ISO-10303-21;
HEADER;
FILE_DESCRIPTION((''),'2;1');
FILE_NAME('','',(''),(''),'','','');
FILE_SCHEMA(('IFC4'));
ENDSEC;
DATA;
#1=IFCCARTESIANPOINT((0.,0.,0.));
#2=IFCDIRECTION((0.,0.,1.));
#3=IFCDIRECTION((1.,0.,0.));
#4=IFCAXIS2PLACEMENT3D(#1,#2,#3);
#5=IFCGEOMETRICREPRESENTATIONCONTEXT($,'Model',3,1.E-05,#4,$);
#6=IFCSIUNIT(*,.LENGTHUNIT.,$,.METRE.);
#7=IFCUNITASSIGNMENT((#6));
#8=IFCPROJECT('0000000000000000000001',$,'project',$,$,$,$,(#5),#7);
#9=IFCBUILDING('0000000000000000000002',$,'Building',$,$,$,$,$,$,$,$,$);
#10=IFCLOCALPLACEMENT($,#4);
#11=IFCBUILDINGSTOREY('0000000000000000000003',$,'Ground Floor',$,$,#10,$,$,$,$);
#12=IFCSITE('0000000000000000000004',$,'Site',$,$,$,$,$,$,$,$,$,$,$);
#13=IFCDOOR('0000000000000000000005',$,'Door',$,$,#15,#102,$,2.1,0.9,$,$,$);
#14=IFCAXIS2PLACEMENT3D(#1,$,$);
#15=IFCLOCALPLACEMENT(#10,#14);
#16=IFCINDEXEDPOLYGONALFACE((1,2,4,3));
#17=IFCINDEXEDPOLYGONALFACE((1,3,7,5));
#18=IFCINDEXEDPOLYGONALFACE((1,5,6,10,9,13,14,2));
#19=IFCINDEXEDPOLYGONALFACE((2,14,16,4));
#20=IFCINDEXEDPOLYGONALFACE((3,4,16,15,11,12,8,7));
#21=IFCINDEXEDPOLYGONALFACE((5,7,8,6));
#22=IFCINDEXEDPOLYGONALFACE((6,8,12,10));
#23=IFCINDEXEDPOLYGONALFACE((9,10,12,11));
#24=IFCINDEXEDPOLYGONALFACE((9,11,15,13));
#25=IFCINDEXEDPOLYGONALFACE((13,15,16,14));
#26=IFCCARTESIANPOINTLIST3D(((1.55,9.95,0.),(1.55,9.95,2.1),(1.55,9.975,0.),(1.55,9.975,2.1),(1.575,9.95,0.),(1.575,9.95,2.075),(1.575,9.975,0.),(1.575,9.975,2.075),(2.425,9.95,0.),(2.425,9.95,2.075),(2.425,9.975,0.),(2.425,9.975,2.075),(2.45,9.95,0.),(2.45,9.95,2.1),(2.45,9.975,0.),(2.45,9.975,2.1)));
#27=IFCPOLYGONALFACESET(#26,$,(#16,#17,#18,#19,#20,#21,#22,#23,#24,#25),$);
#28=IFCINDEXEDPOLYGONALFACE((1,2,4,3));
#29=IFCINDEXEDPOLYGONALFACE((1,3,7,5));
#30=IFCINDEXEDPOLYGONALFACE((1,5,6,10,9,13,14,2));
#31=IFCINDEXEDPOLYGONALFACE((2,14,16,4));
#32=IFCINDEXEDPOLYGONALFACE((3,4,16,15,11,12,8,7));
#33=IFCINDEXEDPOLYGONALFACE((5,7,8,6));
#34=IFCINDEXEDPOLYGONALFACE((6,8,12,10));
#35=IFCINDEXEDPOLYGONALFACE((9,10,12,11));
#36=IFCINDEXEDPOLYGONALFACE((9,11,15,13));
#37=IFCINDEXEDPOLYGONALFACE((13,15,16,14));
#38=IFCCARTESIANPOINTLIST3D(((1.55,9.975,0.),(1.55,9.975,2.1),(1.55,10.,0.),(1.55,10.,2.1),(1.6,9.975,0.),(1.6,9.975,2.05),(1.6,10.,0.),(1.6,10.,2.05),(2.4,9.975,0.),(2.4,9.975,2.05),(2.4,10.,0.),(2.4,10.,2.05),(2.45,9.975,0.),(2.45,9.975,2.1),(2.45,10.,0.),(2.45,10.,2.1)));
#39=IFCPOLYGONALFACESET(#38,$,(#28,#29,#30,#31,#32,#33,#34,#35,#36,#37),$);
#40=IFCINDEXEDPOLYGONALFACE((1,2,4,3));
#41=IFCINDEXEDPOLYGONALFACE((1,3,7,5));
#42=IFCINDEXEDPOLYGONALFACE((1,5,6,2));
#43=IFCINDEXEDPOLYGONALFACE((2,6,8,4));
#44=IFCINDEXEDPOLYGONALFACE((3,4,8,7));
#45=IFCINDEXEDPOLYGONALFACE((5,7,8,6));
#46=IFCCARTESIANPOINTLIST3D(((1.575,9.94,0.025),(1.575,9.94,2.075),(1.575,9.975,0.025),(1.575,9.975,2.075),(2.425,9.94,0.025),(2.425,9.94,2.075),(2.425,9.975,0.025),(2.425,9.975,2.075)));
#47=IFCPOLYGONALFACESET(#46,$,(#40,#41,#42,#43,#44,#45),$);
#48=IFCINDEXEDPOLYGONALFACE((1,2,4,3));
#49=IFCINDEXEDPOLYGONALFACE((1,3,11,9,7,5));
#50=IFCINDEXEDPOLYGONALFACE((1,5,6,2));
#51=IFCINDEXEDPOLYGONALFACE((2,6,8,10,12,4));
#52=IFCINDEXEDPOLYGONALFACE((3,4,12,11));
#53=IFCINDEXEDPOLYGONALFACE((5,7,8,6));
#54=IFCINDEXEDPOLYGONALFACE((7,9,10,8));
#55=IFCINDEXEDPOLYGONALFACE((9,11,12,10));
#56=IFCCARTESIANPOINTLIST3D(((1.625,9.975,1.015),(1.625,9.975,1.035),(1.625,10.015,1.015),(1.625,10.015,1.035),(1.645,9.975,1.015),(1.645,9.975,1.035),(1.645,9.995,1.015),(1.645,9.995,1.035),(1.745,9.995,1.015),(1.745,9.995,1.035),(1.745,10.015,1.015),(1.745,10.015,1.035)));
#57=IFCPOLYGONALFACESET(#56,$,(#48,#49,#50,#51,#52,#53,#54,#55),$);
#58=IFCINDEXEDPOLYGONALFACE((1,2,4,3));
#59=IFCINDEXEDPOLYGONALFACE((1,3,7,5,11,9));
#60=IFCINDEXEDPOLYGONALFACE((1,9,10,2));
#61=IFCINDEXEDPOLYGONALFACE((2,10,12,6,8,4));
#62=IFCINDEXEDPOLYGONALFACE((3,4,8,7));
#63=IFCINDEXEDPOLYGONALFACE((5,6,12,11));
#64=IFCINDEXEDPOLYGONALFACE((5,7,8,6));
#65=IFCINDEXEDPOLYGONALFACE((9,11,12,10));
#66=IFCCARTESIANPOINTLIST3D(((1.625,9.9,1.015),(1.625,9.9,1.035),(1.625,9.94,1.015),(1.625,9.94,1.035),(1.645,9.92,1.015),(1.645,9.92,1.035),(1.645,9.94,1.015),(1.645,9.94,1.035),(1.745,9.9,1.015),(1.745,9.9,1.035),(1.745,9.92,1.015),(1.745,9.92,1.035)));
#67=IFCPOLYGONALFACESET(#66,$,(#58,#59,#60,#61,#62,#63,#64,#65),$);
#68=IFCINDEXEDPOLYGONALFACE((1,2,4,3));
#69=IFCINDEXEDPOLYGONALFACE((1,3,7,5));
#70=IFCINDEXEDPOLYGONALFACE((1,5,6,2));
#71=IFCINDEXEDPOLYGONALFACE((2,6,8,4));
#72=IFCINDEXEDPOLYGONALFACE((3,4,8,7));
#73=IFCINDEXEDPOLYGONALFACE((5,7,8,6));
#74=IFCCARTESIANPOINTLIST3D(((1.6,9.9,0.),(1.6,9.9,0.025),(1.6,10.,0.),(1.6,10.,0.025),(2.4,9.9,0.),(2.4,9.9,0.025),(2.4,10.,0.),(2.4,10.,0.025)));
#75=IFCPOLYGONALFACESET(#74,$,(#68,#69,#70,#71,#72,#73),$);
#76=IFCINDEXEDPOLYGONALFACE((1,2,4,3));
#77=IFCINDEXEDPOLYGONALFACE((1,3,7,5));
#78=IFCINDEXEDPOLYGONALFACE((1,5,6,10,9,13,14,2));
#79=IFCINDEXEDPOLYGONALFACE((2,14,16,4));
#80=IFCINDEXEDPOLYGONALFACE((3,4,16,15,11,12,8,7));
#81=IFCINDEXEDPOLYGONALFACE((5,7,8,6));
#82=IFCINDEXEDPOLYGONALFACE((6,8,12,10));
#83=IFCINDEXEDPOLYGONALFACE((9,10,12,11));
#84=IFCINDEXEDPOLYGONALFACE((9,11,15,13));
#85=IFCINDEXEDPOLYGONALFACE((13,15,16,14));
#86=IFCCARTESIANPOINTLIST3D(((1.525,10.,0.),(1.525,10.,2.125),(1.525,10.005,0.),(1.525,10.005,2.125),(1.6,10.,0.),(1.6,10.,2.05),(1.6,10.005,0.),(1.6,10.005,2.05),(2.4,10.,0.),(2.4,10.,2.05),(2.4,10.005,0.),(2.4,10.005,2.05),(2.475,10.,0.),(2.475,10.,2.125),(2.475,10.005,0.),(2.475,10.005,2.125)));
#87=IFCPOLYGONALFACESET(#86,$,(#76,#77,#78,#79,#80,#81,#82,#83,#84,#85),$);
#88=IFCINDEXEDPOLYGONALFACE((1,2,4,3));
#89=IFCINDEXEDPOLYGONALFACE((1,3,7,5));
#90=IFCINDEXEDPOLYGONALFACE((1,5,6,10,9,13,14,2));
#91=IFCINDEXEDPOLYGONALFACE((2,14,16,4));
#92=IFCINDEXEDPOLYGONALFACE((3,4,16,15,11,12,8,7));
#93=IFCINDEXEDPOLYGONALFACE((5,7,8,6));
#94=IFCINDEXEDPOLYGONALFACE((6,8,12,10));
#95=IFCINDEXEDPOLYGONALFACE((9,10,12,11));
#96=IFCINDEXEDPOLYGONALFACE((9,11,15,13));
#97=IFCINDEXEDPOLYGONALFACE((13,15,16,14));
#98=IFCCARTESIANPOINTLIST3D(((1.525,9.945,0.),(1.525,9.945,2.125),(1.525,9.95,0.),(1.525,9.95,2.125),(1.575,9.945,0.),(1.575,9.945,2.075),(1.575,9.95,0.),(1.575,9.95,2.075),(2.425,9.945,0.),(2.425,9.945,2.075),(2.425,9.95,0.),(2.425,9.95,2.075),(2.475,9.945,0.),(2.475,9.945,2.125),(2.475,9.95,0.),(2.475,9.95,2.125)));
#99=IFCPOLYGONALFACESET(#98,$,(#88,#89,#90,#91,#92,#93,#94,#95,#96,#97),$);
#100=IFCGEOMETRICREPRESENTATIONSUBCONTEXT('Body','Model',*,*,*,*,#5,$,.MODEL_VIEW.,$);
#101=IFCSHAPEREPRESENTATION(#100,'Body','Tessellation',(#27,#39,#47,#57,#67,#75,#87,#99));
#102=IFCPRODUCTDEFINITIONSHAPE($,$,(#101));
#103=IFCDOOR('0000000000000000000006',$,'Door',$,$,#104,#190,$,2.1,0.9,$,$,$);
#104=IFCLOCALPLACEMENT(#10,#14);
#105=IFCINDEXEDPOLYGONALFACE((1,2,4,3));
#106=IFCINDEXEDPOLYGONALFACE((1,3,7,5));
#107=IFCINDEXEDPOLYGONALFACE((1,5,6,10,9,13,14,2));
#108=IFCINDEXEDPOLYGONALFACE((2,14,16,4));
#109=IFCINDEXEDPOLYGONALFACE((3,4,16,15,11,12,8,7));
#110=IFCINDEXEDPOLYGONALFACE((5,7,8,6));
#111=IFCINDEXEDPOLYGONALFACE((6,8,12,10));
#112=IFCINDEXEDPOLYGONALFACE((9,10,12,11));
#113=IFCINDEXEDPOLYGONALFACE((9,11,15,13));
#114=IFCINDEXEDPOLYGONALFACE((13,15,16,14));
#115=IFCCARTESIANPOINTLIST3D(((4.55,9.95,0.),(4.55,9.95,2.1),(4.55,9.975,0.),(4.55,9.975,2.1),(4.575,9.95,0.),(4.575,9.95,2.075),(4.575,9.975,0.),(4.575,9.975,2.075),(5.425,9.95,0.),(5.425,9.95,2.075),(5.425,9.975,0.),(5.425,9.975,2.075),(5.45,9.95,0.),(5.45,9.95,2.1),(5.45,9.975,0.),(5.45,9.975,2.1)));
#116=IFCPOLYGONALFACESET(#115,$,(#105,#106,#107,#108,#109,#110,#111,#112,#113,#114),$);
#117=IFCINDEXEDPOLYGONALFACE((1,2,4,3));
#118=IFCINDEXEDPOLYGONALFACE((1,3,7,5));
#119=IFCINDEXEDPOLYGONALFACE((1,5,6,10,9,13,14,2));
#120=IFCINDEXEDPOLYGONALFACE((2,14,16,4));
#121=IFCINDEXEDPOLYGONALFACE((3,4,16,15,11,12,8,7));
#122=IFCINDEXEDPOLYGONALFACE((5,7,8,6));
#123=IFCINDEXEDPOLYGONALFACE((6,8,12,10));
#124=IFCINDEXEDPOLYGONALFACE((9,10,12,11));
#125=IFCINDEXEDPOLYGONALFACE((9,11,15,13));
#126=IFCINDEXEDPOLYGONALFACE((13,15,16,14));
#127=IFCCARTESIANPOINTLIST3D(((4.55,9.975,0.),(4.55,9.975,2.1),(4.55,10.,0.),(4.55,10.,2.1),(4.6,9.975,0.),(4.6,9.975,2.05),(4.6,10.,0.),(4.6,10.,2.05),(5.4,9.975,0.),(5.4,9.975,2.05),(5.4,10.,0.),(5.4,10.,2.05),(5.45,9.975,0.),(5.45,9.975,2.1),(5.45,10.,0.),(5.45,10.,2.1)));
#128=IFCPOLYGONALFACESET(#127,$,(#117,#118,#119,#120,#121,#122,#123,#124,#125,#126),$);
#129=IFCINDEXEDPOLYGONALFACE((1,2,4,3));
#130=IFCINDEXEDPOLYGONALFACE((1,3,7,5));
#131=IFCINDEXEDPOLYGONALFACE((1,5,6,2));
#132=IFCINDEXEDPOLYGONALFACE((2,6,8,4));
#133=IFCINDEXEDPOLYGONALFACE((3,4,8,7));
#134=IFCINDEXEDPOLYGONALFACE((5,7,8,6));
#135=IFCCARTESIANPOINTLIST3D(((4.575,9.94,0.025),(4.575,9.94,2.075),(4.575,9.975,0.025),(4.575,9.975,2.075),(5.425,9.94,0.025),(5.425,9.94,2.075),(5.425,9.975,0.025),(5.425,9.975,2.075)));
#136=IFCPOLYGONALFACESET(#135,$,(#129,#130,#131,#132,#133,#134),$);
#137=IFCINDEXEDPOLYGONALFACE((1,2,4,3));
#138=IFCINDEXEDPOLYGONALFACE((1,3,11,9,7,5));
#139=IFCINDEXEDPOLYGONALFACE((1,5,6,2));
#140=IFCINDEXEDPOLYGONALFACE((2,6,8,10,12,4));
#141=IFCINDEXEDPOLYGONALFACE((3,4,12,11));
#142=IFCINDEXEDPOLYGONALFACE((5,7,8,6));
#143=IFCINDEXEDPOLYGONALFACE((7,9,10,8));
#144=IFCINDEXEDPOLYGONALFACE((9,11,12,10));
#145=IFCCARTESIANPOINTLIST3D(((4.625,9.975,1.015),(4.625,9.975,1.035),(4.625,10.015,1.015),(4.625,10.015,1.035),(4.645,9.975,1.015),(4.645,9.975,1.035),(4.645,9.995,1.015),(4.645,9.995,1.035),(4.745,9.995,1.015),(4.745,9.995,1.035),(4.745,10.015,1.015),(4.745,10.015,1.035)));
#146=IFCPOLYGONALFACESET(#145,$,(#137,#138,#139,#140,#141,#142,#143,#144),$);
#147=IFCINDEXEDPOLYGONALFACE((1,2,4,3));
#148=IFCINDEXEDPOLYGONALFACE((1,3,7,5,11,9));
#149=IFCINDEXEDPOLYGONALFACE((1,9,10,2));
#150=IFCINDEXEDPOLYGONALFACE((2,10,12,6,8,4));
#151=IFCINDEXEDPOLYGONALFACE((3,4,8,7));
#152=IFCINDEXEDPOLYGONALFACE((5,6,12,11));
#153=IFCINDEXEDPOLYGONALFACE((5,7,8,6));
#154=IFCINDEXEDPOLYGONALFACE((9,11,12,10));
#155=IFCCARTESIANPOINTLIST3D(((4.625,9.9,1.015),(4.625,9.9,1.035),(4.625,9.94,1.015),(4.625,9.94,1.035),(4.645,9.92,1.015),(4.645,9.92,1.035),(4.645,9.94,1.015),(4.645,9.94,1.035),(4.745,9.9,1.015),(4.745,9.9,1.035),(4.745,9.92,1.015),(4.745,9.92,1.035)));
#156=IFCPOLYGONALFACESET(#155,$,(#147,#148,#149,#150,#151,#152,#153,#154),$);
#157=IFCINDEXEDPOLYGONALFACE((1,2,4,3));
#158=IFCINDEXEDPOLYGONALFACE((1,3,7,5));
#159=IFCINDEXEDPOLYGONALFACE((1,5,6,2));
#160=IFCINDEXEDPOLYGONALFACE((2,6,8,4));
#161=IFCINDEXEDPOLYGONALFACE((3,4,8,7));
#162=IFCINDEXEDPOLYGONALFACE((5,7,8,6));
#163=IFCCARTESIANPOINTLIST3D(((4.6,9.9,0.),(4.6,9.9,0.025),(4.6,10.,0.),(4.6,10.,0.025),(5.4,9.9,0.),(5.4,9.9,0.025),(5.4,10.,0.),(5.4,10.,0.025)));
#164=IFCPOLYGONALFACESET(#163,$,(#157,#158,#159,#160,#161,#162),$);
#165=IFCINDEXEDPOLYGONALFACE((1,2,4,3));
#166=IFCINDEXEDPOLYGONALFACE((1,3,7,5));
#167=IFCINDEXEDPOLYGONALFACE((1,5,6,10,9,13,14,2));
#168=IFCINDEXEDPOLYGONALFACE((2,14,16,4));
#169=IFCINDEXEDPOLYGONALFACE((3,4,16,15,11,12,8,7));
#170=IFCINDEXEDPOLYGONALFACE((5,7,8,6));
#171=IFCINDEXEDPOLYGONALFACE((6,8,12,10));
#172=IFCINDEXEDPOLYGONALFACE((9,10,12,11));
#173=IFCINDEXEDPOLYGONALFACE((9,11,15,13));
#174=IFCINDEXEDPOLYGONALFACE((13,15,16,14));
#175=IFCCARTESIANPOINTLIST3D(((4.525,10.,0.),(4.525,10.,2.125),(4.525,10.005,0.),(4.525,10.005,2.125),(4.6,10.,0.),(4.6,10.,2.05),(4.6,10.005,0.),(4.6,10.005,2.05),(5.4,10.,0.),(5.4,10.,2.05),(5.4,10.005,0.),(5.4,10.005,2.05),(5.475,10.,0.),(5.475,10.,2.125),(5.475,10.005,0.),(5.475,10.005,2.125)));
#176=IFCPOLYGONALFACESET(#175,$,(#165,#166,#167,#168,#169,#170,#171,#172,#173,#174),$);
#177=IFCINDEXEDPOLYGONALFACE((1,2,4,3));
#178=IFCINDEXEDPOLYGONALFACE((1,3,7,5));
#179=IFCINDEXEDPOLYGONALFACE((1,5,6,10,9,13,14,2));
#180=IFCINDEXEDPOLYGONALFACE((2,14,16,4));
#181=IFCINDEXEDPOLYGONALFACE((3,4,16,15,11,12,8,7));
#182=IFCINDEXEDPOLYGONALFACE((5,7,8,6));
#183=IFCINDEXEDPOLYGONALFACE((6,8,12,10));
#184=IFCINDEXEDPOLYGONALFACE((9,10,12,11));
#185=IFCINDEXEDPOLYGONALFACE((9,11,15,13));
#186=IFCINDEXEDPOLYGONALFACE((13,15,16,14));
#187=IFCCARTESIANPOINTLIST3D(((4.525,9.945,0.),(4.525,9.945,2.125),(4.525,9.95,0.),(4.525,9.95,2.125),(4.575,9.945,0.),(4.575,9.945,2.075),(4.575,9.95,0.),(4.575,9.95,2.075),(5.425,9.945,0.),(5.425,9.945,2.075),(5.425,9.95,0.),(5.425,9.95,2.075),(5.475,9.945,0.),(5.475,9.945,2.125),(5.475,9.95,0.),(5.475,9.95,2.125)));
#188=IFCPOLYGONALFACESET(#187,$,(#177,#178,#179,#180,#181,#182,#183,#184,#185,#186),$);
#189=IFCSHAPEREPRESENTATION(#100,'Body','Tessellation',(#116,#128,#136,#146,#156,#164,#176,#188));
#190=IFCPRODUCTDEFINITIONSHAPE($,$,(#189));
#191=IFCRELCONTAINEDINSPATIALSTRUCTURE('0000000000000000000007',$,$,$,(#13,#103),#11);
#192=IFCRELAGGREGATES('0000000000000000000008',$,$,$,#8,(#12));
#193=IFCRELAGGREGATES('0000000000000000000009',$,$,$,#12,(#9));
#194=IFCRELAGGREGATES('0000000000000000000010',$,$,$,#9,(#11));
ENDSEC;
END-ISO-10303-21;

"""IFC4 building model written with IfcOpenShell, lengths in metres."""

from ifc_helpers import new_model, si_unit, frame, origin_with_axes, place, context, subcontext, project, spatial, line, indexed_curve, outline, extrude, element, save


model = new_model("IFC4")

# Units and contexts
model_context = context("Model", 3, precision=1e-05, world=origin_with_axes())
body_context = subcontext(model_context, "Body", "Model", "MODEL_VIEW")
ifc_project = project(units=[si_unit("LENGTHUNIT", "METRE")], contexts=[model_context])

# Site, building, storey
site = spatial("IfcSite", under=ifc_project, Name="Site")
building = spatial("IfcBuilding", under=site, Name="Building")
storey_placement = place(None, origin_with_axes())
storey = spatial("IfcBuildingStorey", under=building, at=storey_placement, Name="Ground Floor")

# Doors
door_1_placement = place(storey_placement, frame((2.45, 10.0, 0.0), z_axis=(0.0, 0.0, 1.0), x_axis=(-1.0, 0.0, 0.0)))
element("IfcDoor", 1, at=door_1_placement, inside=storey, Name="Door", OverallHeight=2.1, OverallWidth=0.9, context=body_context, shape_type="SweptSolid", body=[
    extrude(outline(indexed_curve([(0.0, 0.0), (0.0, 2.1), (0.9, 2.1), (0.9, 0.0), (0.875, 0.0), (0.875, 2.075), (0.025, 2.075), (0.025, 0.0)], segments=[line(1, 2, 3, 4, 5, 6, 7, 8, 1)])), frame((0.0, 0.025, 0.0), z_axis=(0.0, -1.0, 0.0), x_axis=(1.0, 0.0, 0.0)), (0.0, 0.0, -1.0), 0.025),
    extrude(outline(indexed_curve([(0.0, 0.0), (0.0, 2.1), (0.9, 2.1), (0.9, 0.0), (0.85, 0.0), (0.85, 2.05), (0.05, 2.05), (0.05, 0.0)], segments=[line(1, 2, 3, 4, 5, 6, 7, 8, 1)])), frame((0.0, 0.0, 0.0), z_axis=(0.0, -1.0, 0.0), x_axis=(1.0, 0.0, 0.0)), (0.0, 0.0, -1.0), 0.025),
    extrude(outline(indexed_curve([(0.0, 0.0), (0.85, 0.0), (0.85, 0.035), (0.0, 0.035)], segments=[line(1, 2, 3, 4, 1)])), frame((0.025, 0.025, 0.025), z_axis=(0.0, 0.0, 1.0), x_axis=(1.0, 0.0, 0.0)), (0.0, 0.0, 1.0), 2.05),
    extrude(outline(indexed_curve([(0.0, 0.0), (0.0, -0.04), (-0.12, -0.04), (-0.12, -0.02), (-0.02, -0.02), (-0.02, 0.0)], segments=[line(1, 2, 3, 4, 5, 6, 1)])), frame((0.825, 0.025, 1.015), z_axis=(0.0, 0.0, 1.0), x_axis=(1.0, 0.0, 0.0)), (0.0, 0.0, 1.0), 0.02),
    extrude(outline(indexed_curve([(0.0, 0.0), (0.0, 0.04), (-0.12, 0.04), (-0.12, 0.02), (-0.02, 0.02), (-0.02, 0.0)], segments=[line(1, 2, 3, 4, 5, 6, 1)])), frame((0.825, 0.06, 1.015), z_axis=(0.0, 0.0, 1.0), x_axis=(1.0, 0.0, 0.0)), (0.0, 0.0, 1.0), 0.02),
    extrude(outline(indexed_curve([(0.0, 0.0), (0.8, 0.0), (0.8, 0.1), (0.0, 0.1)], segments=[line(1, 2, 3, 4, 1)])), frame((0.05, 0.0, 0.0), z_axis=(0.0, 0.0, 1.0), x_axis=(1.0, 0.0, 0.0)), (0.0, 0.0, 1.0), 0.025),
    extrude(outline(indexed_curve([(0.0, 0.0), (0.0, 2.125), (0.95, 2.125), (0.95, 0.0), (0.875, 0.0), (0.875, 2.05), (0.075, 2.05), (0.075, 0.0)], segments=[line(1, 2, 3, 4, 5, 6, 7, 8, 1)])), frame((-0.025, -0.005, 0.0), z_axis=(0.0, -1.0, 0.0), x_axis=(1.0, 0.0, 0.0)), (0.0, 0.0, -1.0), 0.005),
    extrude(outline(indexed_curve([(0.0, 0.0), (0.0, 2.125), (0.95, 2.125), (0.95, 0.0), (0.9, 0.0), (0.9, 2.075), (0.05, 2.075), (0.05, 0.0)], segments=[line(1, 2, 3, 4, 5, 6, 7, 8, 1)])), frame((-0.025, 0.05, 0.0), z_axis=(0.0, -1.0, 0.0), x_axis=(1.0, 0.0, 0.0)), (0.0, 0.0, -1.0), 0.005),
])
door_2_placement = place(storey_placement, frame((5.45, 10.0, 0.0), z_axis=(0.0, 0.0, 1.0), x_axis=(-1.0, 0.0, 0.0)))
element("IfcDoor", 2, at=door_2_placement, inside=storey, Name="Door", OverallHeight=2.1, OverallWidth=0.9, context=body_context, shape_type="SweptSolid", body=[
    extrude(outline(indexed_curve([(0.0, 0.0), (0.0, 2.1), (0.9, 2.1), (0.9, 0.0), (0.875, 0.0), (0.875, 2.075), (0.025, 2.075), (0.025, 0.0)], segments=[line(1, 2, 3, 4, 5, 6, 7, 8, 1)])), frame((0.0, 0.025, 0.0), z_axis=(0.0, -1.0, 0.0), x_axis=(1.0, 0.0, 0.0)), (0.0, 0.0, -1.0), 0.025),
    extrude(outline(indexed_curve([(0.0, 0.0), (0.0, 2.1), (0.9, 2.1), (0.9, 0.0), (0.85, 0.0), (0.85, 2.05), (0.05, 2.05), (0.05, 0.0)], segments=[line(1, 2, 3, 4, 5, 6, 7, 8, 1)])), frame((0.0, 0.0, 0.0), z_axis=(0.0, -1.0, 0.0), x_axis=(1.0, 0.0, 0.0)), (0.0, 0.0, -1.0), 0.025),
    extrude(outline(indexed_curve([(0.0, 0.0), (0.85, 0.0), (0.85, 0.035), (0.0, 0.035)], segments=[line(1, 2, 3, 4, 1)])), frame((0.025, 0.025, 0.025), z_axis=(0.0, 0.0, 1.0), x_axis=(1.0, 0.0, 0.0)), (0.0, 0.0, 1.0), 2.05),
    extrude(outline(indexed_curve([(0.0, 0.0), (0.0, -0.04), (-0.12, -0.04), (-0.12, -0.02), (-0.02, -0.02), (-0.02, 0.0)], segments=[line(1, 2, 3, 4, 5, 6, 1)])), frame((0.825, 0.025, 1.015), z_axis=(0.0, 0.0, 1.0), x_axis=(1.0, 0.0, 0.0)), (0.0, 0.0, 1.0), 0.02),
    extrude(outline(indexed_curve([(0.0, 0.0), (0.0, 0.04), (-0.12, 0.04), (-0.12, 0.02), (-0.02, 0.02), (-0.02, 0.0)], segments=[line(1, 2, 3, 4, 5, 6, 1)])), frame((0.825, 0.06, 1.015), z_axis=(0.0, 0.0, 1.0), x_axis=(1.0, 0.0, 0.0)), (0.0, 0.0, 1.0), 0.02),
    extrude(outline(indexed_curve([(0.0, 0.0), (0.8, 0.0), (0.8, 0.1), (0.0, 0.1)], segments=[line(1, 2, 3, 4, 1)])), frame((0.05, 0.0, 0.0), z_axis=(0.0, 0.0, 1.0), x_axis=(1.0, 0.0, 0.0)), (0.0, 0.0, 1.0), 0.025),
    extrude(outline(indexed_curve([(0.0, 0.0), (0.0, 2.125), (0.95, 2.125), (0.95, 0.0), (0.875, 0.0), (0.875, 2.05), (0.075, 2.05), (0.075, 0.0)], segments=[line(1, 2, 3, 4, 5, 6, 7, 8, 1)])), frame((-0.025, -0.005, 0.0), z_axis=(0.0, -1.0, 0.0), x_axis=(1.0, 0.0, 0.0)), (0.0, 0.0, -1.0), 0.005),
    extrude(outline(indexed_curve([(0.0, 0.0), (0.0, 2.125), (0.95, 2.125), (0.95, 0.0), (0.9, 0.0), (0.9, 2.075), (0.05, 2.075), (0.05, 0.0)], segments=[line(1, 2, 3, 4, 5, 6, 7, 8, 1)])), frame((-0.025, 0.05, 0.0), z_axis=(0.0, -1.0, 0.0), x_axis=(1.0, 0.0, 0.0)), (0.0, 0.0, -1.0), 0.005),
])

save(model, "model.ifc")
